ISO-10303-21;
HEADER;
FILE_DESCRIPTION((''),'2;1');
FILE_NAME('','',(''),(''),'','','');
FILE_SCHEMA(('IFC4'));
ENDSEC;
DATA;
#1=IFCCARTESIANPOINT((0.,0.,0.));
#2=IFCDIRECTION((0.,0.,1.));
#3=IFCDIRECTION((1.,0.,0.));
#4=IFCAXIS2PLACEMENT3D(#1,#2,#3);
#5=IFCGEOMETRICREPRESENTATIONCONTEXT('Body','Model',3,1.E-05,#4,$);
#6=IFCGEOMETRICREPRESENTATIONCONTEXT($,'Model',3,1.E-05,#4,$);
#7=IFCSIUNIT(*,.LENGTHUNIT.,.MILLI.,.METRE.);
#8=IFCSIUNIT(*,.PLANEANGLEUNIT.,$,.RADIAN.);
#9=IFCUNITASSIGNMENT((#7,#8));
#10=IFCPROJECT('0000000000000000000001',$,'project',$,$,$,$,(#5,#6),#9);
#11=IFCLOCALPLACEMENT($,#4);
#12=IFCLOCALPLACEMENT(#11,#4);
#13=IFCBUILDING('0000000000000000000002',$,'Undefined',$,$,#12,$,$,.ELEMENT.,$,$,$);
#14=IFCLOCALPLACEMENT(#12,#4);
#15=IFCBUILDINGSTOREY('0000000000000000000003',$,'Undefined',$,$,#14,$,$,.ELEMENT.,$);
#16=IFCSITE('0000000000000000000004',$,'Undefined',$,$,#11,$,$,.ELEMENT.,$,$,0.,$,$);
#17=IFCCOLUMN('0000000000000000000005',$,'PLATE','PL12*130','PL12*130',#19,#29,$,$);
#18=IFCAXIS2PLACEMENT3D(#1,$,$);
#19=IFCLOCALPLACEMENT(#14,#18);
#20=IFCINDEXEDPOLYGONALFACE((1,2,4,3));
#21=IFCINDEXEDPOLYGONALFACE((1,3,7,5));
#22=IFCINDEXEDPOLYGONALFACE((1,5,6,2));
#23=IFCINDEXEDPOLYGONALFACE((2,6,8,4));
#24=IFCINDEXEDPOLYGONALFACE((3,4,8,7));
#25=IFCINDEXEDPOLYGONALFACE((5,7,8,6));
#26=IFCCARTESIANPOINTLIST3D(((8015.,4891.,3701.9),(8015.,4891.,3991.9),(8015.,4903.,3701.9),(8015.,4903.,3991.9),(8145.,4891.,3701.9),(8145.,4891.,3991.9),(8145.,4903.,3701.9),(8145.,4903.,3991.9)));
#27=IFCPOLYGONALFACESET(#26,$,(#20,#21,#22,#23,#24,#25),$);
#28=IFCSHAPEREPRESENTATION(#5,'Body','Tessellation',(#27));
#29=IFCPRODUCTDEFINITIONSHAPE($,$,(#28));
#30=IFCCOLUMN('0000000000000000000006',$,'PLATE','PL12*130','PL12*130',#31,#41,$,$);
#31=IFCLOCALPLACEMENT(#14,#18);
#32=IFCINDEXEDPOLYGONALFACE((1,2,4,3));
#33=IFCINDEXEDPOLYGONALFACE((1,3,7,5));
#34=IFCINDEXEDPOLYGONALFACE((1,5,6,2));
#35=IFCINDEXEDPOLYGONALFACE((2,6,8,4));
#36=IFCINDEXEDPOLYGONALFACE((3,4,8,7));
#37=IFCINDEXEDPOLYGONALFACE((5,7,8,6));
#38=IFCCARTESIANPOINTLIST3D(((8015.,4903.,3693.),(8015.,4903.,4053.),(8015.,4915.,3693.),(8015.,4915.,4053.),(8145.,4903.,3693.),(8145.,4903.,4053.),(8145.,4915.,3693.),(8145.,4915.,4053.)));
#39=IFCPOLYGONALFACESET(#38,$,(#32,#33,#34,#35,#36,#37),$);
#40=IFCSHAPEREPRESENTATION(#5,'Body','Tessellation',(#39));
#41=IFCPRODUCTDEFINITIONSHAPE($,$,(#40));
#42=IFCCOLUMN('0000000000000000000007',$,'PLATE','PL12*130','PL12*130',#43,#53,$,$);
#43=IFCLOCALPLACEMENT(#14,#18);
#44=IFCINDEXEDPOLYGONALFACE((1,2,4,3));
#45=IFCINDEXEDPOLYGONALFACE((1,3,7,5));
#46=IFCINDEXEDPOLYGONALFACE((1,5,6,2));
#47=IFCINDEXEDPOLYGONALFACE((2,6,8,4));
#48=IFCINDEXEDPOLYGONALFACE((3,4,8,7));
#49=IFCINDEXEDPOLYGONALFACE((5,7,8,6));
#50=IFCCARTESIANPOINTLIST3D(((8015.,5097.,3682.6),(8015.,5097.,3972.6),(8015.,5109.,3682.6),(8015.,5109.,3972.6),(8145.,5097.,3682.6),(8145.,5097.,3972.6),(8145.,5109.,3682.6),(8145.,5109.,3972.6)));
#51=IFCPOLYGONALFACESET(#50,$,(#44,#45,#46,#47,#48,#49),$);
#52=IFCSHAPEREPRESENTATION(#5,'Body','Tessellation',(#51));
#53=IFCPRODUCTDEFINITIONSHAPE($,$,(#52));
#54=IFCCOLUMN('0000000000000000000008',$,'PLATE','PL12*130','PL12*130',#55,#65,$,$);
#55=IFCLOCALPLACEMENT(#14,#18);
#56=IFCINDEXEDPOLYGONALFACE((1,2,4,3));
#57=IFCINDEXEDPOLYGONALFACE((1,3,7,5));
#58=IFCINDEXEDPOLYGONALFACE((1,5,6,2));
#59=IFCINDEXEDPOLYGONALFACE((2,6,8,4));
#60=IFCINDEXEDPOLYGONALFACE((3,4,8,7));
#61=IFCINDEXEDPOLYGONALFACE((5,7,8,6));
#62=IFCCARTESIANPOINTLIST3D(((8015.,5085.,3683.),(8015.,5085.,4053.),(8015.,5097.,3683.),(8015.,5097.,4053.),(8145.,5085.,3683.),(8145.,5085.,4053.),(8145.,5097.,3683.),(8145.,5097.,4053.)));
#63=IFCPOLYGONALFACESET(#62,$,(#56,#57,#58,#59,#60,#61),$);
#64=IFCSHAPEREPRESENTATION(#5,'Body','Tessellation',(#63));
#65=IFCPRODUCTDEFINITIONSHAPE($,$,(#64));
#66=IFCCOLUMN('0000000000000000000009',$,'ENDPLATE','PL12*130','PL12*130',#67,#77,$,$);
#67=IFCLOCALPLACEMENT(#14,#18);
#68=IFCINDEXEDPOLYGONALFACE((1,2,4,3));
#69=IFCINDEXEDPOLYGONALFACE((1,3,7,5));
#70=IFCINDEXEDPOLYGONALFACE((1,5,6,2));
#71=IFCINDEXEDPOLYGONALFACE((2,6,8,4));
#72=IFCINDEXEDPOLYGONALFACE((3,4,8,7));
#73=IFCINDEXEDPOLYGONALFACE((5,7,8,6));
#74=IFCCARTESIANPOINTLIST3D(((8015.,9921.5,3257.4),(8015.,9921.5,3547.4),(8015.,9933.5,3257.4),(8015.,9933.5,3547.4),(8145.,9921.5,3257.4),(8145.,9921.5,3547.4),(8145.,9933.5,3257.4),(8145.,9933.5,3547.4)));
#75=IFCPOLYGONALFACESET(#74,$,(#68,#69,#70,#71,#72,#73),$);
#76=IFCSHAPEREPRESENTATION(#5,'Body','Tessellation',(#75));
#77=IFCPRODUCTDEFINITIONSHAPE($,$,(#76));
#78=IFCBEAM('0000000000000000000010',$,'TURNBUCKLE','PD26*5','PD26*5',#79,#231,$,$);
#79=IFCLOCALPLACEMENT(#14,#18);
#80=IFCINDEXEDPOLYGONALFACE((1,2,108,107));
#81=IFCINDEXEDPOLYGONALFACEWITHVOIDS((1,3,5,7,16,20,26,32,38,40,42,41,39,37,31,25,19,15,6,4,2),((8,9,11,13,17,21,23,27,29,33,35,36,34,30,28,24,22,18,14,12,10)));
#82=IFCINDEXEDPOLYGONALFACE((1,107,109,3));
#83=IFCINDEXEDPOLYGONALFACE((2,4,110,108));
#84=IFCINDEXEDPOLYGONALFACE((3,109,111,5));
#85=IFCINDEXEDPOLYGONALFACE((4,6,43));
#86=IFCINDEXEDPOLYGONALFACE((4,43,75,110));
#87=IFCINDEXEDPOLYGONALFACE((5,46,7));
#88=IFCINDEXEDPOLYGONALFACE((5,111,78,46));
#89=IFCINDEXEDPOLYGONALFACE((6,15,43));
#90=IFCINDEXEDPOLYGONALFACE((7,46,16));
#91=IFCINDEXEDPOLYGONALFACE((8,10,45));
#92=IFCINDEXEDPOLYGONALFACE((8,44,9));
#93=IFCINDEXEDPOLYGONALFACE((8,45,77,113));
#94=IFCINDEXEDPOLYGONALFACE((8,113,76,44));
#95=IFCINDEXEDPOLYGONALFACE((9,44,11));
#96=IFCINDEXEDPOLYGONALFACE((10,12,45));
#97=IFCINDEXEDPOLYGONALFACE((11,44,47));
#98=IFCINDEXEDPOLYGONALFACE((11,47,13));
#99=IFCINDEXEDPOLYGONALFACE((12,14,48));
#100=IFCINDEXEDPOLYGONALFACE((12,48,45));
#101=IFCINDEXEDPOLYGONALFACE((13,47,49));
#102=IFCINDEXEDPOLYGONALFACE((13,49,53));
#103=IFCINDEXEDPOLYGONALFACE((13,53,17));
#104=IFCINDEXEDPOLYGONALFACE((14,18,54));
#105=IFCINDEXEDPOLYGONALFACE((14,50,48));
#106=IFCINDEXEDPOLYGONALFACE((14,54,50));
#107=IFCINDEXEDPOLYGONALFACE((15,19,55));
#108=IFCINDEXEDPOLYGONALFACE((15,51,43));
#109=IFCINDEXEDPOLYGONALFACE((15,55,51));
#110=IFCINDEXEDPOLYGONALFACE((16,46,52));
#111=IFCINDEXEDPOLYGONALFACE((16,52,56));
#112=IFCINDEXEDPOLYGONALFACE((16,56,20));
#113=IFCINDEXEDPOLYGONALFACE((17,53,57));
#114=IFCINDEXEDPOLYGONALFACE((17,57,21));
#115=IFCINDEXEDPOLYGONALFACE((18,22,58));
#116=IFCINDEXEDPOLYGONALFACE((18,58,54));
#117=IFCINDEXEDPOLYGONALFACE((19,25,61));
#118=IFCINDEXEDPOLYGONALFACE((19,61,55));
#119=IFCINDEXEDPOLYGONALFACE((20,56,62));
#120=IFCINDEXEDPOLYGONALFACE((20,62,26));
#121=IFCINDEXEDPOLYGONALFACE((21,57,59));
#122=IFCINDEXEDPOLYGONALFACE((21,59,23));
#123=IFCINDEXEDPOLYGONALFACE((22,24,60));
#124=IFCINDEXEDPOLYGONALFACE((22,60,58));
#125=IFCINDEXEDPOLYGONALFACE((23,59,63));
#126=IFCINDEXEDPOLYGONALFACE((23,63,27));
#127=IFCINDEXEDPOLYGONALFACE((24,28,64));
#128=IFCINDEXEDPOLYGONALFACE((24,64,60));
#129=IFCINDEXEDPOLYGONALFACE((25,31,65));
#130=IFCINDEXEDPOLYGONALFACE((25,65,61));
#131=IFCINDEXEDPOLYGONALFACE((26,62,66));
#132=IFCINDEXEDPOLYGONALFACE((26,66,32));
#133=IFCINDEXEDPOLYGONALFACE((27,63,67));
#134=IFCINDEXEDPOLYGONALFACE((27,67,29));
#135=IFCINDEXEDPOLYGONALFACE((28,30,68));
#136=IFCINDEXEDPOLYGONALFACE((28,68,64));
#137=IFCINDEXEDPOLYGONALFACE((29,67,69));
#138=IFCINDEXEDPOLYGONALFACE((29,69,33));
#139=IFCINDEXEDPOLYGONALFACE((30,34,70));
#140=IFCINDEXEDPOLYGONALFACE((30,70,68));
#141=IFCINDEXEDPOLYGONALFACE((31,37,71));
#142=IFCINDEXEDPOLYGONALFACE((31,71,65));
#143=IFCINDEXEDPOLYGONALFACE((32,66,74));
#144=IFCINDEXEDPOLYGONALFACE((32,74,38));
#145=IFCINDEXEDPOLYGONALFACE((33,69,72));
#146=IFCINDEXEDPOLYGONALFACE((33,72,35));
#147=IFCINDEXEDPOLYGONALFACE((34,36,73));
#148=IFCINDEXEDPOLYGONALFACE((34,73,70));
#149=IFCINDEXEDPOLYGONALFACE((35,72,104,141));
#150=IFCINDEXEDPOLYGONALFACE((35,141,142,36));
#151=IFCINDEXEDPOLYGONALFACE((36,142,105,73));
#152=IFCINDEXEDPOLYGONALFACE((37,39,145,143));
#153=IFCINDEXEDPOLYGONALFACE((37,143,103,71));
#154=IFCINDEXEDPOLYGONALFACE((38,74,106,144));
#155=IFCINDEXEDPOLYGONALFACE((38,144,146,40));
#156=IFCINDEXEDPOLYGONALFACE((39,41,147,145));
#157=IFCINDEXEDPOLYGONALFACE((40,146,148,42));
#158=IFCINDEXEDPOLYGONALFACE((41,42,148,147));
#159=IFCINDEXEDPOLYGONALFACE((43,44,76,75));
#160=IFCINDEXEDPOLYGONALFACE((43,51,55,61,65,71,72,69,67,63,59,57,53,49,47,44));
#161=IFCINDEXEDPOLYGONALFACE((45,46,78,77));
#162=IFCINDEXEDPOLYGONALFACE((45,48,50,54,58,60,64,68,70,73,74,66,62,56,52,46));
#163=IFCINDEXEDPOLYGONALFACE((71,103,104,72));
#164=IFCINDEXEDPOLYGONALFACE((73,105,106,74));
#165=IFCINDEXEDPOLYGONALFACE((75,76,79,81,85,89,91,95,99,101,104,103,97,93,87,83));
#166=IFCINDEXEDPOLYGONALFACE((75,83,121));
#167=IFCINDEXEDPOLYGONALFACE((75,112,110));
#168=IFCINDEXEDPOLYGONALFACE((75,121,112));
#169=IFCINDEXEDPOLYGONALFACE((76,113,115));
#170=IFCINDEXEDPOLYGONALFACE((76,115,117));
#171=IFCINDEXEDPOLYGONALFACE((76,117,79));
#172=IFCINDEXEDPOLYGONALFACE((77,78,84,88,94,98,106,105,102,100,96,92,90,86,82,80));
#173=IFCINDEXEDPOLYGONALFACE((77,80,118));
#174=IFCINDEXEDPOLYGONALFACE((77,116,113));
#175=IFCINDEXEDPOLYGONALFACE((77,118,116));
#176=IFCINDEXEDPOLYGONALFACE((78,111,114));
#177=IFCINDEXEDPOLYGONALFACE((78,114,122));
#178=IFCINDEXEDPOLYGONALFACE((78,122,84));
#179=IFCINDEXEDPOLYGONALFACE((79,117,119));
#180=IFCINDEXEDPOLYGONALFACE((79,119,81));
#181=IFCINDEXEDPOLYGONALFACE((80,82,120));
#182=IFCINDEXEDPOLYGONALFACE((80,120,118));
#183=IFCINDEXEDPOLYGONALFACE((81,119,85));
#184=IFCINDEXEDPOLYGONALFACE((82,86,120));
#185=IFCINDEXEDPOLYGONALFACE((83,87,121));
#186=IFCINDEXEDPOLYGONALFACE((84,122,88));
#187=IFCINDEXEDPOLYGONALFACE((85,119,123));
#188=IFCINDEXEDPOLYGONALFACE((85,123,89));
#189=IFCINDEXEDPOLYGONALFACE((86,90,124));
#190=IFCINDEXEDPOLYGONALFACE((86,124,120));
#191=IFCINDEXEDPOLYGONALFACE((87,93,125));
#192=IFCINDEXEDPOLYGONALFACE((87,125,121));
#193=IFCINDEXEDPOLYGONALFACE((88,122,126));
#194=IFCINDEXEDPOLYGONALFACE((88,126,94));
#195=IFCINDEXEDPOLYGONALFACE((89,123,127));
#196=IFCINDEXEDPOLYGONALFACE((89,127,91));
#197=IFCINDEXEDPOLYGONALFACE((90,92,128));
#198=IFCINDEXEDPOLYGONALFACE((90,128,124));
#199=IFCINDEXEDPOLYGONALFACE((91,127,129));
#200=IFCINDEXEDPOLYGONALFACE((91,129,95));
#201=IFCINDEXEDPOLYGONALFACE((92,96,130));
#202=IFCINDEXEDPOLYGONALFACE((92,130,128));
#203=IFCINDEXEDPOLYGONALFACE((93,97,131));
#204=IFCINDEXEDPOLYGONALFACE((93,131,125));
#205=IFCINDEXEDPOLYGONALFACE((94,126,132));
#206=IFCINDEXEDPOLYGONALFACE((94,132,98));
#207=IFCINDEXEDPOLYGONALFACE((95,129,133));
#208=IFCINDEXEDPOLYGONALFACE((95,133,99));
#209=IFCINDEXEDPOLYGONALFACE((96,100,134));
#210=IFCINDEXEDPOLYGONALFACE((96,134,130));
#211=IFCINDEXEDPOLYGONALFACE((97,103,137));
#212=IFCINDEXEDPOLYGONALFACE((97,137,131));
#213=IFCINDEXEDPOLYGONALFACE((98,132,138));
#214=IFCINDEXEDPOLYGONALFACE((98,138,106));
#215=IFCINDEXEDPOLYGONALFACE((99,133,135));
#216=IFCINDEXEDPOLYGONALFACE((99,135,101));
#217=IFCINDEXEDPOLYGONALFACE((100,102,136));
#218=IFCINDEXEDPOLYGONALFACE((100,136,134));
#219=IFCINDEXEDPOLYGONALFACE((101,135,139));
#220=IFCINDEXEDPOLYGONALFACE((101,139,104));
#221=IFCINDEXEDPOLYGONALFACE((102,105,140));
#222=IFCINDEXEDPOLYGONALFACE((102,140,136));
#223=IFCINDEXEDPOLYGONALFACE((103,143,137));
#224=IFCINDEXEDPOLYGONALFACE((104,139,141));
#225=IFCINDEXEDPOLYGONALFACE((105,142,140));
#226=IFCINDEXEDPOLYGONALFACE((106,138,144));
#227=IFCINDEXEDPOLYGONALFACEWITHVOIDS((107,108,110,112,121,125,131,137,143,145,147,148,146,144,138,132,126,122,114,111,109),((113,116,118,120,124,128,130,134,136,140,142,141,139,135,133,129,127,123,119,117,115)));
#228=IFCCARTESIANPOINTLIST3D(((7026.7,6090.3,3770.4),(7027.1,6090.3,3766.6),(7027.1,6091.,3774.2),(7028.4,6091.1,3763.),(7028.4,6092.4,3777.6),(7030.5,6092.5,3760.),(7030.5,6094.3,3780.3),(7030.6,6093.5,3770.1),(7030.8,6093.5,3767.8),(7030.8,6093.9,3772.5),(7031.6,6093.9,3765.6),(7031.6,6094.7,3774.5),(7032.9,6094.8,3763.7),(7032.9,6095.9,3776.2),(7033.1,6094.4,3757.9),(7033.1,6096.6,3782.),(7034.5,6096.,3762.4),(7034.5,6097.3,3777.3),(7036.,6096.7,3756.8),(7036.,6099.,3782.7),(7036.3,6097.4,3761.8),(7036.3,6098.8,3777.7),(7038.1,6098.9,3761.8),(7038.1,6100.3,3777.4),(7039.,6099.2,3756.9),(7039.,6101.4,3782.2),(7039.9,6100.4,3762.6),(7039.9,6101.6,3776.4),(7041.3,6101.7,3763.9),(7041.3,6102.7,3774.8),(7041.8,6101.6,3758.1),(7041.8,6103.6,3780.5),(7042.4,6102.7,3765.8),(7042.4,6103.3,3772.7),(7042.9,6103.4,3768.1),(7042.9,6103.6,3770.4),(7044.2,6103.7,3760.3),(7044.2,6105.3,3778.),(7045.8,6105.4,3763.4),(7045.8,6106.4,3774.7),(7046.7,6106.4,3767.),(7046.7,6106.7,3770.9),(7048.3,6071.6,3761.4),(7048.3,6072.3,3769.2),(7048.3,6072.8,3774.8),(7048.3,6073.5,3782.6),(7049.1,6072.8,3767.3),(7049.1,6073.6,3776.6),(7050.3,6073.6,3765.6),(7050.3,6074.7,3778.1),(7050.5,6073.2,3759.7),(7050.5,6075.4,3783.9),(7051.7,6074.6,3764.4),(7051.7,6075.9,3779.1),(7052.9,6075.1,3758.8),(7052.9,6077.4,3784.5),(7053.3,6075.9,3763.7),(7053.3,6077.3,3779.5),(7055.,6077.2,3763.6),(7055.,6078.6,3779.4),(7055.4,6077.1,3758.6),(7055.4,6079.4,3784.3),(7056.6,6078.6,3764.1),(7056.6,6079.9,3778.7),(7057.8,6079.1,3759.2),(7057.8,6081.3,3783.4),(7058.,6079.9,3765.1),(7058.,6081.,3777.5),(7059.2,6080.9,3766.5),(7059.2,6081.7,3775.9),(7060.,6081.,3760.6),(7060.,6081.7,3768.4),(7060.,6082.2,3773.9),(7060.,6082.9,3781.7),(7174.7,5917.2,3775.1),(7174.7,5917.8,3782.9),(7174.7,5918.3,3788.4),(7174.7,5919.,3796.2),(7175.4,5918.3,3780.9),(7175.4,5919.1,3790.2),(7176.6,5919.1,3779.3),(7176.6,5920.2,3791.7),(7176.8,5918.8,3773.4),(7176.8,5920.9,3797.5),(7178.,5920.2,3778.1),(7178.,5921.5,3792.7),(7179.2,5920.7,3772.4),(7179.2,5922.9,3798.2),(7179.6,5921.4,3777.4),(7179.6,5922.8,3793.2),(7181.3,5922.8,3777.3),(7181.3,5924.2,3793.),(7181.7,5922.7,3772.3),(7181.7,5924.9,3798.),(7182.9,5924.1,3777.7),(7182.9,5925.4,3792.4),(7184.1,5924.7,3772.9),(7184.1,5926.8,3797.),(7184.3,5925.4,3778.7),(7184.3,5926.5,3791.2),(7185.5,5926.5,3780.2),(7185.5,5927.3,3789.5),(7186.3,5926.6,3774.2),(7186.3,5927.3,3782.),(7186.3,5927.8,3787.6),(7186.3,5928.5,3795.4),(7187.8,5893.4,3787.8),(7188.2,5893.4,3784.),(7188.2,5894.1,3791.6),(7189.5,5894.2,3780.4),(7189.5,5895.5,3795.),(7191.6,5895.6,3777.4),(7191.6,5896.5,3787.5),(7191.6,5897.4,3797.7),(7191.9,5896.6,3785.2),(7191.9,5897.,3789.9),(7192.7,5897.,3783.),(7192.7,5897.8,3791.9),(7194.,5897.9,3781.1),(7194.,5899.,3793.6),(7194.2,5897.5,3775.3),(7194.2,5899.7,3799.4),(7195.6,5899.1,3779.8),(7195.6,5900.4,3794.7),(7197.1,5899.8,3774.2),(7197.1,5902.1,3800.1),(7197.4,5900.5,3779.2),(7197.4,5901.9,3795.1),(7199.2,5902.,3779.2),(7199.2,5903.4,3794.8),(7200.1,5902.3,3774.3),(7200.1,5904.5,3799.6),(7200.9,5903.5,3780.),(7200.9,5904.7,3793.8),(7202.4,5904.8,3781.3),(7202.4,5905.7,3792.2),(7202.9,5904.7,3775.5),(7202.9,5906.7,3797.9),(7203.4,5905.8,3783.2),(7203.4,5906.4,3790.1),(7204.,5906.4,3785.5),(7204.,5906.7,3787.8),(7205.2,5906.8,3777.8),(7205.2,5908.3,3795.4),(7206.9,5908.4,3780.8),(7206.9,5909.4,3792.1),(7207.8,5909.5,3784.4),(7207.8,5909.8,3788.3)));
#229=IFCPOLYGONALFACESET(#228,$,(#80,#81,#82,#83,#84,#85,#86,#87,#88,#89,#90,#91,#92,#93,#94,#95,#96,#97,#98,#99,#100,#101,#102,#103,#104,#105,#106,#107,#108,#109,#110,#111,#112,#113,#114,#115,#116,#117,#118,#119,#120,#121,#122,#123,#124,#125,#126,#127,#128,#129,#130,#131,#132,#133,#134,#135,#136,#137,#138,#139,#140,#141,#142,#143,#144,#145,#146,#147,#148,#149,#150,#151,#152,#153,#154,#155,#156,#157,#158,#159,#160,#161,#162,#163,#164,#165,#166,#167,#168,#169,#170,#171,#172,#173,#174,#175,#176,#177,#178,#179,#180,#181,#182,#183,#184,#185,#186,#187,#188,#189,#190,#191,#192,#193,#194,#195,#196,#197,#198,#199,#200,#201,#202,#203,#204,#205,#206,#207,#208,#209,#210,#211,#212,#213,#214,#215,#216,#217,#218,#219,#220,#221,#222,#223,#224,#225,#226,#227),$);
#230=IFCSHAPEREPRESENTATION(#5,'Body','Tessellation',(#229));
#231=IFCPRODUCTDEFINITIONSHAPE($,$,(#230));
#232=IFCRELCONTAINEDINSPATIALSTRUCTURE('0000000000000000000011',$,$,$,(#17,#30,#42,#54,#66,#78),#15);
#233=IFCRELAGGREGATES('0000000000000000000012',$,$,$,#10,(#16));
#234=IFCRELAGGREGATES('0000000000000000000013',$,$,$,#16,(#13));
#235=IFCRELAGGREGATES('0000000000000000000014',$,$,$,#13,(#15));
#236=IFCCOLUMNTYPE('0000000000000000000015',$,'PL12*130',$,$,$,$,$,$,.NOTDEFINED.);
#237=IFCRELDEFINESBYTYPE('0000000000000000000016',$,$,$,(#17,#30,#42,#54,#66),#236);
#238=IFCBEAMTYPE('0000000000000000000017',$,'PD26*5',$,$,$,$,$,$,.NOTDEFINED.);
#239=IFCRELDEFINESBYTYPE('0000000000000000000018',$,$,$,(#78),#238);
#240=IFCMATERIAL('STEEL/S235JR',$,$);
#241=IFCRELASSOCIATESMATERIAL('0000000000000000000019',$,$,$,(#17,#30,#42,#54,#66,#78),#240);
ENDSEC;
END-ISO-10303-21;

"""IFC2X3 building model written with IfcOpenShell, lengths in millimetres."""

from ifc_helpers import new_model, si_unit, frame, origin_with_axes, origin_2d_with_axis, place, context, project, spatial, rectangle, hollow_circle, extrude, material, type_object, element, save


model = new_model("IFC2X3")

# Units and contexts
model_context_1 = context("Model", 3, precision=1e-05, world=origin_with_axes(), identifier="Body")
model_context_2 = context("Model", 3, precision=1e-05, world=origin_with_axes())
ifc_project = project(units=[si_unit("LENGTHUNIT", "METRE", prefix="MILLI"), si_unit("PLANEANGLEUNIT", "RADIAN")], contexts=[model_context_1, model_context_2])

# Site, building, storey
site_placement = place(None, origin_with_axes())
site = spatial("IfcSite", under=ifc_project, at=site_placement, Name="Undefined", CompositionType="ELEMENT", RefElevation=0.0)
building_placement = place(site_placement, origin_with_axes())
building = spatial("IfcBuilding", under=site, at=building_placement, Name="Undefined", CompositionType="ELEMENT")
storey_placement = place(building_placement, origin_with_axes())
storey = spatial("IfcBuildingStorey", under=building, at=storey_placement, Name="Undefined", CompositionType="ELEMENT")

# Columns
ifc_material = material(Name="STEEL/S235JR")
column_type = type_object("IfcColumnType", Name="PL12*130", PredefinedType="NOTDEFINED")
column_1_placement = place(storey_placement, frame((8080.0, 4897.0, 3701.9), z_axis=(0.0, 0.0, 1.0), x_axis=(1.0, 0.0, 0.0)))
element("IfcColumn", 1, at=column_1_placement, inside=storey, type_object=column_type, material=ifc_material, Name="PLATE", Description="PL12*130", ObjectType="PL12*130", context=model_context_1, shape_type="SweptSolid", body=[
    extrude(rectangle(XDim=12.0, YDim=130.0, at=origin_2d_with_axis()), frame((0.0, 0.0, 290.0), z_axis=(0.0, 0.0, -1.0), x_axis=(0.0, 1.0, 0.0)), (0.0, 0.0, 1.0), 290.0),
])
column_2_placement = place(storey_placement, frame((8080.0, 4909.0, 3693.0), z_axis=(0.0, 0.0, 1.0), x_axis=(1.0, 0.0, 0.0)))
element("IfcColumn", 2, at=column_2_placement, inside=storey, type_object=column_type, material=ifc_material, Name="PLATE", Description="PL12*130", ObjectType="PL12*130", context=model_context_1, shape_type="SweptSolid", body=[
    extrude(rectangle(XDim=12.0, YDim=130.0, at=origin_2d_with_axis()), frame((0.0, 0.0, 360.0), z_axis=(0.0, 0.0, -1.0), x_axis=(0.0, 1.0, 0.0)), (0.0, 0.0, 1.0), 360.0),
])
column_3_placement = place(storey_placement, frame((8080.0, 5103.0, 3682.6), z_axis=(0.0, 0.0, 1.0), x_axis=(1.0, 0.0, 0.0)))
element("IfcColumn", 3, at=column_3_placement, inside=storey, type_object=column_type, material=ifc_material, Name="PLATE", Description="PL12*130", ObjectType="PL12*130", context=model_context_1, shape_type="SweptSolid", body=[
    extrude(rectangle(XDim=12.0, YDim=130.0, at=origin_2d_with_axis()), frame((0.0, 0.0, 290.0), z_axis=(0.0, 0.0, -1.0), x_axis=(0.0, 1.0, 0.0)), (0.0, 0.0, 1.0), 290.0),
])
column_4_placement = place(storey_placement, frame((8080.0, 5091.0, 3683.0), z_axis=(0.0, 0.0, 1.0), x_axis=(1.0, 0.0, 0.0)))
element("IfcColumn", 4, at=column_4_placement, inside=storey, type_object=column_type, material=ifc_material, Name="PLATE", Description="PL12*130", ObjectType="PL12*130", context=model_context_1, shape_type="SweptSolid", body=[
    extrude(rectangle(XDim=12.0, YDim=130.0, at=origin_2d_with_axis()), frame((0.0, 0.0, 370.0), z_axis=(0.0, 0.0, -1.0), x_axis=(0.0, 1.0, 0.0)), (0.0, 0.0, 1.0), 370.0),
])
column_5_placement = place(storey_placement, frame((8080.0, 9927.5, 3257.4), z_axis=(0.0, 0.0, 1.0), x_axis=(1.0, 0.0, 0.0)))
element("IfcColumn", 5, at=column_5_placement, inside=storey, type_object=column_type, material=ifc_material, Name="ENDPLATE", Description="PL12*130", ObjectType="PL12*130", context=model_context_1, shape_type="SweptSolid", body=[
    extrude(rectangle(XDim=12.0, YDim=130.0, at=origin_2d_with_axis()), frame((0.0, 0.0, 290.0), z_axis=(0.0, 0.0, -1.0), x_axis=(0.0, -1.0, 0.0)), (0.0, 0.0, 1.0), 290.0),
])

# Beam, opening
beam_type_1 = type_object("IfcBeamType", Name="PD26*5", PredefinedType="NOTDEFINED")
beam_1_placement = place(storey_placement, frame((7197.8, 5901.6, 3787.1), z_axis=(0.0, -0.088027, -0.996118), x_axis=(-0.631673, 0.772225, -0.068242)))
beam_1 = element("IfcBeam", 6, at=beam_1_placement, inside=storey, type_object=beam_type_1, material=ifc_material, Name="TURNBUCKLE", Description="PD26*5", ObjectType="PD26*5", context=model_context_1, shape_type="SweptSolid", body=[
    extrude(hollow_circle(Radius=13.0, WallThickness=5.0, at=origin_2d_with_axis()), frame((255.0, 0.0, 0.0), z_axis=(-1.0, 0.0, 0.0), x_axis=(0.0, -1.0, 0.0)), (0.0, 0.0, 1.0), 255.0),
])
opening_placement = place(storey_placement, frame((7197.8, 5901.6, 3787.1), z_axis=(0.0, -0.088027, -0.996118), x_axis=(-0.631673, 0.772225, -0.068242)))
element("IfcOpeningElement", 7, at=opening_placement, cuts=beam_1, ObjectType="Recess", context=model_context_1, shape_type="SweptSolid", body=[
    extrude(rectangle(XDim=15.0, YDim=52.0, at=origin_2d_with_axis()), frame((227.5, 0.0, 0.0), z_axis=(-1.0, 0.0, 0.0), x_axis=(0.0, -1.0, 0.0)), (0.0, 0.0, 1.0), 200.0),
])

save(model, "model.ifc")
